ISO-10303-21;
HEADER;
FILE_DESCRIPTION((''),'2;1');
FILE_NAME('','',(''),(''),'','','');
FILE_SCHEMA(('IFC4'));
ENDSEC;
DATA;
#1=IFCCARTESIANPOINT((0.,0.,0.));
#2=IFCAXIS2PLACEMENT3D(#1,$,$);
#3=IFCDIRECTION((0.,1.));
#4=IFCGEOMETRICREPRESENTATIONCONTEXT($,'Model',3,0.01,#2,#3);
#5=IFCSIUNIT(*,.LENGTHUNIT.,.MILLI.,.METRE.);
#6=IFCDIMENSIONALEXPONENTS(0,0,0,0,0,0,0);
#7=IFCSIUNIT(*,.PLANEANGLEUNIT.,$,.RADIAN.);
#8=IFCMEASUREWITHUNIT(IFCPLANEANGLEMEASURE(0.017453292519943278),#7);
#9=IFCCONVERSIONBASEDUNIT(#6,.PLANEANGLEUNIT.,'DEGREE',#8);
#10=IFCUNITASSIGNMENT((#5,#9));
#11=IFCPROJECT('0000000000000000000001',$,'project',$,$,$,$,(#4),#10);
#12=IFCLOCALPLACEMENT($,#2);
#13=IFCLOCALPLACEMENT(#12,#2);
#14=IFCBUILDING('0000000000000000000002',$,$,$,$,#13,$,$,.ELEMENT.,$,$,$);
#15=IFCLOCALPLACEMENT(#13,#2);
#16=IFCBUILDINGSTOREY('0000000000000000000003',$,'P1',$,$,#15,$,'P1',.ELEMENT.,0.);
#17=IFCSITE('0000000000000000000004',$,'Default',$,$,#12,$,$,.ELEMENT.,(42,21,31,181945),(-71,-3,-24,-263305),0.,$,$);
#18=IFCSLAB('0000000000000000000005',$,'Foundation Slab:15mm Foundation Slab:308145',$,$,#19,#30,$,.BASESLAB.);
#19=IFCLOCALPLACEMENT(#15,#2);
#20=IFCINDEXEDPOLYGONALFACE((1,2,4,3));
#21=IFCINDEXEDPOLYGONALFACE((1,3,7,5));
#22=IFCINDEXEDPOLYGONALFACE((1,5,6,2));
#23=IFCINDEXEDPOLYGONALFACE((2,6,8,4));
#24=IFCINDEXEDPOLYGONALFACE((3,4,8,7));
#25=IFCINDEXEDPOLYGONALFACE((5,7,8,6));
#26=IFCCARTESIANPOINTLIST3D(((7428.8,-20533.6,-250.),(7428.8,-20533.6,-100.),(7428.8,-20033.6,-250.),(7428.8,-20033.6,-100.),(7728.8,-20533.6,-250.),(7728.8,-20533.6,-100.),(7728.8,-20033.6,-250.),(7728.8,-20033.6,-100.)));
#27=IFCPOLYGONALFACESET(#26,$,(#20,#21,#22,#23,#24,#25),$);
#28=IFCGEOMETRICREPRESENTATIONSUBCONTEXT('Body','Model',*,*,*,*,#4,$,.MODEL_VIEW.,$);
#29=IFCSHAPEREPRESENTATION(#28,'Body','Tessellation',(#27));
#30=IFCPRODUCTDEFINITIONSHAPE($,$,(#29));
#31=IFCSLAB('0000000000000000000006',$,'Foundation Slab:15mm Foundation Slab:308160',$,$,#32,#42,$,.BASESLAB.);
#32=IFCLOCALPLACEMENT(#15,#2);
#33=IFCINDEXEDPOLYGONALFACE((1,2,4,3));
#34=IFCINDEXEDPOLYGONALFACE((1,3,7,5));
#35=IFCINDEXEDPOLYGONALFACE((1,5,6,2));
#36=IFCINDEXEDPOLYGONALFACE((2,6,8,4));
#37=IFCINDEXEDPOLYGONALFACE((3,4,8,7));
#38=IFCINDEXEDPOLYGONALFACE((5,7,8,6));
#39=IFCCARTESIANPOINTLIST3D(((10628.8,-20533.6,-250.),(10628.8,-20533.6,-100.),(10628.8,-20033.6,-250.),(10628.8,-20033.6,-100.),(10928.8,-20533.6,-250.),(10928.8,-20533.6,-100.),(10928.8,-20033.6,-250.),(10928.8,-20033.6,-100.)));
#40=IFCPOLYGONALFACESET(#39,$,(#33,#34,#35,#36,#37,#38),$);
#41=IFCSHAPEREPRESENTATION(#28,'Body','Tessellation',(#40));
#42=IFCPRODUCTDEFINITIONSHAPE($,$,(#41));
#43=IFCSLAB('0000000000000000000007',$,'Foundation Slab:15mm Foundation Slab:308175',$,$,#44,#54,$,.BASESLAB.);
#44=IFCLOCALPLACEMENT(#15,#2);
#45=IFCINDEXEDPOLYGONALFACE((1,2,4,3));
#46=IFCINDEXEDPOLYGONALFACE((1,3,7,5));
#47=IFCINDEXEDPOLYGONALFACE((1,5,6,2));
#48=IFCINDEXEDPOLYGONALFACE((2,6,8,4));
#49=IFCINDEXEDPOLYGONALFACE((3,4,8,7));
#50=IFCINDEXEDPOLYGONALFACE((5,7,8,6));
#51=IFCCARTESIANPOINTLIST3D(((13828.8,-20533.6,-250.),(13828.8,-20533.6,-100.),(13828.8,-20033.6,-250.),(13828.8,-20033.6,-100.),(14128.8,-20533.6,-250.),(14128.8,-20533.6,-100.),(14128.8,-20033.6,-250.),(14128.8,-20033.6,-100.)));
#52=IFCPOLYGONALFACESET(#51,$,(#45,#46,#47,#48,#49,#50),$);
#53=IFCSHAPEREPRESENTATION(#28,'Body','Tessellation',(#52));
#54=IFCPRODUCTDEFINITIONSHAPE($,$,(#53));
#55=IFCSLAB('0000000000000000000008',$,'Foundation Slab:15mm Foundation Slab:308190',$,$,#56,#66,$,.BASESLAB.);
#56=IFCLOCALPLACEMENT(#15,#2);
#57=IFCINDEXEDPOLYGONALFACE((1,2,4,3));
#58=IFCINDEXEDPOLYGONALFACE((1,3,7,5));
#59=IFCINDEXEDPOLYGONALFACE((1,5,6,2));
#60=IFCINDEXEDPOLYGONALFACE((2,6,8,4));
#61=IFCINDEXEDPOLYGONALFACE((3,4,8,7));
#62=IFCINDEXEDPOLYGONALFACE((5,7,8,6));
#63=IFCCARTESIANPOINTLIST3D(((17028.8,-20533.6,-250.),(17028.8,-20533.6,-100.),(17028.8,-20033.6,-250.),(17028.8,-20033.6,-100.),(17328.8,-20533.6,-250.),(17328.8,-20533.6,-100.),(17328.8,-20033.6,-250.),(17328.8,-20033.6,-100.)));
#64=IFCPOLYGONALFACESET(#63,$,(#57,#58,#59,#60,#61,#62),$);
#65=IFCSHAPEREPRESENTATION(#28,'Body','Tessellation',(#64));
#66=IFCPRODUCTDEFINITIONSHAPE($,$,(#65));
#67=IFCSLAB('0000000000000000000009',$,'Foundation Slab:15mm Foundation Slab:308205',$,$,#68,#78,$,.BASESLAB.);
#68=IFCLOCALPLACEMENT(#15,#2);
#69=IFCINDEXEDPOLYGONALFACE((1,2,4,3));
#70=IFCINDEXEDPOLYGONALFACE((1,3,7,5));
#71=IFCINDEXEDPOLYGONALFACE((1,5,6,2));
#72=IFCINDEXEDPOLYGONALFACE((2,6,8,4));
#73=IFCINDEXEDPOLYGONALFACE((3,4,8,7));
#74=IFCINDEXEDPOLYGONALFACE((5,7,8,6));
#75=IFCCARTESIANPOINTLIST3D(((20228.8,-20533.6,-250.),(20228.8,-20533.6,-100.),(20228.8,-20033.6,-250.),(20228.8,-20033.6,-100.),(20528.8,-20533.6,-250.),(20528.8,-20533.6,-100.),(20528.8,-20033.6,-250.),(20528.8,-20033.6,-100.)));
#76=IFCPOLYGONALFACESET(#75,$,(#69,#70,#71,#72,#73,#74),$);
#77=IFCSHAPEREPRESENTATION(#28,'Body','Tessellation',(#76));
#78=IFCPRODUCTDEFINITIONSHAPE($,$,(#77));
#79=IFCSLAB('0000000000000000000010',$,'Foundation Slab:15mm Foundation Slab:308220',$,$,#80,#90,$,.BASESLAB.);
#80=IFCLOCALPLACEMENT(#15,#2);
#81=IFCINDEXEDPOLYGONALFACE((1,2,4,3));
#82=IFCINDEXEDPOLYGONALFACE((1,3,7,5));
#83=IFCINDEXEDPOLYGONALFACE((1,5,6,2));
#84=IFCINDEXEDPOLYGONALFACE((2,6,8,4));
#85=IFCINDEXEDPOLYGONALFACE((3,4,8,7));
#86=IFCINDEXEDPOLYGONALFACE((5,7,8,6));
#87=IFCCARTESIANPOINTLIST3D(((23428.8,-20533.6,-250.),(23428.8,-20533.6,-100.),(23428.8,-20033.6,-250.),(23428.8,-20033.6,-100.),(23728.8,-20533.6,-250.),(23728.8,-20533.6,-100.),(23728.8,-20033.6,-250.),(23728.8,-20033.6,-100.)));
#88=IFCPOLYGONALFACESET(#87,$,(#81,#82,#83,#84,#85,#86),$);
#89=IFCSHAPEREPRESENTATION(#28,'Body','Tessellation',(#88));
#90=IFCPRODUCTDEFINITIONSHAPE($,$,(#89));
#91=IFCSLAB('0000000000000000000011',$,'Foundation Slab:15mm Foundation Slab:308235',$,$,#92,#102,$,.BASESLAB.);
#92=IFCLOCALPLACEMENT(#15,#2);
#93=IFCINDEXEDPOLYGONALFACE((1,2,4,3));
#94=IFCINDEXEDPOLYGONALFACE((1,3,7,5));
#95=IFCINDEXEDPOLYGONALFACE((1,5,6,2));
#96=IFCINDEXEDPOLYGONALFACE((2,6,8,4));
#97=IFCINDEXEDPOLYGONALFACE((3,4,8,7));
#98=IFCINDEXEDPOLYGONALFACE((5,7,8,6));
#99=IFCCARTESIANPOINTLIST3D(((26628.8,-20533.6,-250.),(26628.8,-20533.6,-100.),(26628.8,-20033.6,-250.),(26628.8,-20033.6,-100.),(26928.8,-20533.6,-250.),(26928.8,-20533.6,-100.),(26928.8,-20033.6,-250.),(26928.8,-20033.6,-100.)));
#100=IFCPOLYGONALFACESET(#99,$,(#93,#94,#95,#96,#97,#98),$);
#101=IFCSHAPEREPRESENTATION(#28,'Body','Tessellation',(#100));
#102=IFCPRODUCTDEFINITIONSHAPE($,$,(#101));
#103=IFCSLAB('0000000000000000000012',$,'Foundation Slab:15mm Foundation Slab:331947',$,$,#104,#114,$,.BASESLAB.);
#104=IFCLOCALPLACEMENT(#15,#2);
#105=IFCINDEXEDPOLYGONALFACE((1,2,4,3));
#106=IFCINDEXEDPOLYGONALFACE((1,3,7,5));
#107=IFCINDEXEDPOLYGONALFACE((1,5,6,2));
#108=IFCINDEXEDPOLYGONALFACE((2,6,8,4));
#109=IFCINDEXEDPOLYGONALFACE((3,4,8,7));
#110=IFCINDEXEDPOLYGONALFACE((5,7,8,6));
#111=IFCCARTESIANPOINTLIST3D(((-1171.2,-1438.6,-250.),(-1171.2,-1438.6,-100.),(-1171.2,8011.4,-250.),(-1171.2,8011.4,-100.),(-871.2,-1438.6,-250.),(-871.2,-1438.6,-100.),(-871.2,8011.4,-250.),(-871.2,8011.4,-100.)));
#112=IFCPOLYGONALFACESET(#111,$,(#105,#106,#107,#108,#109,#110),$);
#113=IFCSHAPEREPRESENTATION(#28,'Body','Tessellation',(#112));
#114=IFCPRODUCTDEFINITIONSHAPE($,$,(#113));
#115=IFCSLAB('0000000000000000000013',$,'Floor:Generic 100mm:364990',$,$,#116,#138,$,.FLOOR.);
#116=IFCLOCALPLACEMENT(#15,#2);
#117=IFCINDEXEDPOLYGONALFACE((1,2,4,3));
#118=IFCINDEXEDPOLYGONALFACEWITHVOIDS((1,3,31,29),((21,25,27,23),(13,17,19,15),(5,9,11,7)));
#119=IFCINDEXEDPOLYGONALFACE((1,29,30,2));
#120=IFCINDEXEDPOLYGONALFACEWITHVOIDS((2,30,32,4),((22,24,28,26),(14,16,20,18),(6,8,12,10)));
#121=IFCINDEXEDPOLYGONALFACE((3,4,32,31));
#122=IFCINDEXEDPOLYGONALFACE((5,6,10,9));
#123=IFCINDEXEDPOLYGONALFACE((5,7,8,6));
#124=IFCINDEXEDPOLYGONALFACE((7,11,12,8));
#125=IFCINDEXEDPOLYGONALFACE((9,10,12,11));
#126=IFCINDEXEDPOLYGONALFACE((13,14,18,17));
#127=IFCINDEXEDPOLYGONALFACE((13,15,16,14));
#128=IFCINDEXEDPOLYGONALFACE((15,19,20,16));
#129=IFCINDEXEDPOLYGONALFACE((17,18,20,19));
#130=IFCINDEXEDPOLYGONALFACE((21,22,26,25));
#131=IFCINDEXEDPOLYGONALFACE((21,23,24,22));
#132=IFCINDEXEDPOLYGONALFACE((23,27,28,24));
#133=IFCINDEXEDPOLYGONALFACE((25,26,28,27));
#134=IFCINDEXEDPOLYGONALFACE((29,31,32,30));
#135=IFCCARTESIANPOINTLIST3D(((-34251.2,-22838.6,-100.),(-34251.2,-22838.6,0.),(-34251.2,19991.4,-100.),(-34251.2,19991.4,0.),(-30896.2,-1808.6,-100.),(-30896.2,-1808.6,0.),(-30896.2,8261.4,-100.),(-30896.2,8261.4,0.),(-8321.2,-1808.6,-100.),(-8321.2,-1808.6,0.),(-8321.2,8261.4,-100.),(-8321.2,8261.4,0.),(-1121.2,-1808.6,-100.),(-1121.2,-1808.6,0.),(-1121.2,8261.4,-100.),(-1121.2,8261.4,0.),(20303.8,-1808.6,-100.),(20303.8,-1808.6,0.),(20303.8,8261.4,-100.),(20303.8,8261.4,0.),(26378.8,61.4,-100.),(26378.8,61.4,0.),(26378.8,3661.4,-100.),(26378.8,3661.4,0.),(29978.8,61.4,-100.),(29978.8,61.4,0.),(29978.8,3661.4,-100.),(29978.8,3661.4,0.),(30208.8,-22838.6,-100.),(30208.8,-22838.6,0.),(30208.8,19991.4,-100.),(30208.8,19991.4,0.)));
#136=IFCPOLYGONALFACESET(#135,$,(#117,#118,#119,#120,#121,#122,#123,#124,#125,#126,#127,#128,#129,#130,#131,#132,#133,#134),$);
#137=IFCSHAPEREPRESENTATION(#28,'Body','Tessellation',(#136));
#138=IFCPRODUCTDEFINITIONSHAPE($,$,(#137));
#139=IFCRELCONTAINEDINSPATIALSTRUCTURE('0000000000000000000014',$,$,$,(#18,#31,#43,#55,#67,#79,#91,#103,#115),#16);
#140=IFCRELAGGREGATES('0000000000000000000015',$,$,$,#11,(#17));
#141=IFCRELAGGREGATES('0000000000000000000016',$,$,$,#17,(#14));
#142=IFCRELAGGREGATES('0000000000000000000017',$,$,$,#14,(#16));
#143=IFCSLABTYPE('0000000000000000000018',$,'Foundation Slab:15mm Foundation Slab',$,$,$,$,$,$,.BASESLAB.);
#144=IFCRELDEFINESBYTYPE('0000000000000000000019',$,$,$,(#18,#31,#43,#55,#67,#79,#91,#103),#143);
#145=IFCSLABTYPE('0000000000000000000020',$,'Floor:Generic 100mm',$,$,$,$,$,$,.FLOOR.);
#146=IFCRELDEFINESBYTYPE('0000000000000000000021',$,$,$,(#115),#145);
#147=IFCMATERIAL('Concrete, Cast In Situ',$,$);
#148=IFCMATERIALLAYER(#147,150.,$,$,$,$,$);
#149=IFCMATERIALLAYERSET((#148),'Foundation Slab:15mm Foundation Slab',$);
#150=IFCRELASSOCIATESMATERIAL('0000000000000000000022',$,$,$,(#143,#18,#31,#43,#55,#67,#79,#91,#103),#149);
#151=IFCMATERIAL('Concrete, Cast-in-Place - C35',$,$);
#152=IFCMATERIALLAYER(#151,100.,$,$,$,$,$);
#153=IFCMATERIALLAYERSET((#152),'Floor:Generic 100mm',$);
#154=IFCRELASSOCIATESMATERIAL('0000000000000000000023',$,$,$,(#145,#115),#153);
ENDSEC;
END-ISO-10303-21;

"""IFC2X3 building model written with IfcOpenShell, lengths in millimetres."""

from ifc_helpers import new_model, entity, si_unit, converted_unit, direction, frame, frame_2d, origin, origin_2d_with_axis, place, context, subcontext, project, spatial, rectangle, extrude, boolean, material, layer, layer_set, layer_usage, type_object, element, save


model = new_model("IFC2X3")

# Units and contexts
model_context = context("Model", 3, precision=0.01, world=origin(), true_north=direction((0.0, 1.0)))
body_context = subcontext(model_context, "Body", "Model", "MODEL_VIEW")
ifc_project = project(units=[si_unit("LENGTHUNIT", "METRE", prefix="MILLI"), converted_unit("PLANEANGLEUNIT", "DEGREE", entity("IfcPlaneAngleMeasure", 0.017453292519943278), si_unit("PLANEANGLEUNIT", "RADIAN"), dimensions=[0, 0, 0, 0, 0, 0, 0])], contexts=[model_context])

# Site, building, storey
site_placement = place(None, origin())
site = spatial("IfcSite", under=ifc_project, at=site_placement, Name="Default", CompositionType="ELEMENT", RefLatitude=(42, 21, 31, 181945), RefLongitude=(-71, -3, -24, -263305), RefElevation=0.0)
building_placement = place(site_placement, origin())
building = spatial("IfcBuilding", under=site, at=building_placement, CompositionType="ELEMENT")
storey_placement = place(building_placement, origin())
storey = spatial("IfcBuildingStorey", under=building, at=storey_placement, Name="P1", LongName="P1", CompositionType="ELEMENT", Elevation=0.0)

# Shared definitions
ifc_material_1 = material(Name="Concrete, Cast-in-Place - C35")

# Slabs
ifc_material_2 = material(Name="Concrete, Cast In Situ")
ifc_layer_1 = layer(ifc_material_2, 150.0)
ifc_layer_set_1 = layer_set([ifc_layer_1], Name="Foundation Slab:15mm Foundation Slab")
slab_type_1 = type_object("IfcSlabType", Name="Foundation Slab:15mm Foundation Slab", PredefinedType="BASESLAB", material=ifc_layer_set_1)
ifc_layer_usage_1 = layer_usage(ifc_layer_set_1, "AXIS3", "POSITIVE", 0.0)
slab_1_placement = place(storey_placement, origin())
element("IfcSlab", 1, at=slab_1_placement, inside=storey, type_object=slab_type_1, material=ifc_layer_usage_1, Name="Foundation Slab:15mm Foundation Slab:308145", PredefinedType="BASESLAB", context=body_context, shape_type="SweptSolid", body=[
    extrude(rectangle(XDim=500.0, YDim=300.0, at=origin_2d_with_axis()), frame((7578.8, -20283.6, -100.0), z_axis=(0.0, 0.0, -1.0), x_axis=(0.0, 1.0, 0.0)), (0.0, 0.0, 1.0), 150.0),
])
ifc_layer_usage_2 = layer_usage(ifc_layer_set_1, "AXIS3", "POSITIVE", 0.0)
slab_2_placement = place(storey_placement, origin())
element("IfcSlab", 2, at=slab_2_placement, inside=storey, type_object=slab_type_1, material=ifc_layer_usage_2, Name="Foundation Slab:15mm Foundation Slab:308160", PredefinedType="BASESLAB", context=body_context, shape_type="SweptSolid", body=[
    extrude(rectangle(XDim=500.0, YDim=300.0, at=origin_2d_with_axis()), frame((10778.8, -20283.6, -100.0), z_axis=(0.0, 0.0, -1.0), x_axis=(0.0, 1.0, 0.0)), (0.0, 0.0, 1.0), 150.0),
])
ifc_layer_usage_3 = layer_usage(ifc_layer_set_1, "AXIS3", "POSITIVE", 0.0)
slab_3_placement = place(storey_placement, origin())
element("IfcSlab", 3, at=slab_3_placement, inside=storey, type_object=slab_type_1, material=ifc_layer_usage_3, Name="Foundation Slab:15mm Foundation Slab:308175", PredefinedType="BASESLAB", context=body_context, shape_type="SweptSolid", body=[
    extrude(rectangle(XDim=500.0, YDim=300.0, at=origin_2d_with_axis()), frame((13978.8, -20283.6, -100.0), z_axis=(0.0, 0.0, -1.0), x_axis=(0.0, 1.0, 0.0)), (0.0, 0.0, 1.0), 150.0),
])
ifc_layer_usage_4 = layer_usage(ifc_layer_set_1, "AXIS3", "POSITIVE", 0.0)
slab_4_placement = place(storey_placement, origin())
element("IfcSlab", 4, at=slab_4_placement, inside=storey, type_object=slab_type_1, material=ifc_layer_usage_4, Name="Foundation Slab:15mm Foundation Slab:308190", PredefinedType="BASESLAB", context=body_context, shape_type="SweptSolid", body=[
    extrude(rectangle(XDim=500.0, YDim=300.0, at=origin_2d_with_axis()), frame((17178.8, -20283.6, -100.0), z_axis=(0.0, 0.0, -1.0), x_axis=(0.0, 1.0, 0.0)), (0.0, 0.0, 1.0), 150.0),
])
ifc_layer_usage_5 = layer_usage(ifc_layer_set_1, "AXIS3", "POSITIVE", 0.0)
slab_5_placement = place(storey_placement, origin())
element("IfcSlab", 5, at=slab_5_placement, inside=storey, type_object=slab_type_1, material=ifc_layer_usage_5, Name="Foundation Slab:15mm Foundation Slab:308205", PredefinedType="BASESLAB", context=body_context, shape_type="SweptSolid", body=[
    extrude(rectangle(XDim=500.0, YDim=300.0, at=origin_2d_with_axis()), frame((20378.8, -20283.6, -100.0), z_axis=(0.0, 0.0, -1.0), x_axis=(0.0, 1.0, 0.0)), (0.0, 0.0, 1.0), 150.0),
])
ifc_layer_usage_6 = layer_usage(ifc_layer_set_1, "AXIS3", "POSITIVE", 0.0)
slab_6_placement = place(storey_placement, origin())
element("IfcSlab", 6, at=slab_6_placement, inside=storey, type_object=slab_type_1, material=ifc_layer_usage_6, Name="Foundation Slab:15mm Foundation Slab:308220", PredefinedType="BASESLAB", context=body_context, shape_type="SweptSolid", body=[
    extrude(rectangle(XDim=500.0, YDim=300.0, at=origin_2d_with_axis()), frame((23578.8, -20283.6, -100.0), z_axis=(0.0, 0.0, -1.0), x_axis=(0.0, 1.0, 0.0)), (0.0, 0.0, 1.0), 150.0),
])
ifc_layer_usage_7 = layer_usage(ifc_layer_set_1, "AXIS3", "POSITIVE", 0.0)
slab_7_placement = place(storey_placement, origin())
element("IfcSlab", 7, at=slab_7_placement, inside=storey, type_object=slab_type_1, material=ifc_layer_usage_7, Name="Foundation Slab:15mm Foundation Slab:308235", PredefinedType="BASESLAB", context=body_context, shape_type="SweptSolid", body=[
    extrude(rectangle(XDim=500.0, YDim=300.0, at=origin_2d_with_axis()), frame((26778.8, -20283.6, -100.0), z_axis=(0.0, 0.0, -1.0), x_axis=(0.0, 1.0, 0.0)), (0.0, 0.0, 1.0), 150.0),
])
ifc_layer_usage_8 = layer_usage(ifc_layer_set_1, "AXIS3", "POSITIVE", 0.0)
slab_8_placement = place(storey_placement, origin())
element("IfcSlab", 8, at=slab_8_placement, inside=storey, type_object=slab_type_1, material=ifc_layer_usage_8, Name="Foundation Slab:15mm Foundation Slab:331947", PredefinedType="BASESLAB", context=body_context, shape_type="SweptSolid", body=[
    extrude(rectangle(XDim=9450.0, YDim=300.0, at=frame_2d((0.0, 0.0), x_axis=(1.0, 0.0))), frame((-1021.2, 3286.4, -100.0), z_axis=(0.0, 0.0, -1.0), x_axis=(0.0, 1.0, 0.0)), (0.0, 0.0, 1.0), 150.0),
])

# Slab, openings
ifc_layer_2 = layer(ifc_material_1, 100.0)
ifc_layer_set_2 = layer_set([ifc_layer_2], Name="Floor:Generic 100mm")
ifc_layer_usage_9 = layer_usage(ifc_layer_set_2, "AXIS3", "POSITIVE", 0.0)
slab_type_2 = type_object("IfcSlabType", Name="Floor:Generic 100mm", PredefinedType="FLOOR", material=ifc_layer_set_2)
slab_9_placement = place(storey_placement, origin())
slab_9 = element("IfcSlab", 9, at=slab_9_placement, inside=storey, type_object=slab_type_2, material=ifc_layer_usage_9, Name="Floor:Generic 100mm:364990", PredefinedType="FLOOR", context=body_context, shape_type="CSG", body=[
    boolean("DIFFERENCE", boolean("DIFFERENCE", boolean("DIFFERENCE", extrude(rectangle(XDim=42830.0, YDim=64460.0, at=origin_2d_with_axis()), frame((-2021.2, -1423.6, 0.0), z_axis=(0.0, 0.0, -1.0), x_axis=(0.0, 1.0, 0.0)), (0.0, 0.0, 1.0), 100.0), extrude(rectangle(XDim=10070.0, YDim=22575.0, at=origin_2d_with_axis()), frame((-19608.7, 3226.4, -100.0), z_axis=(0.0, 0.0, 1.0), x_axis=(0.0, 1.0, 0.0)), (0.0, 0.0, 1.0), 100.0)), extrude(rectangle(XDim=10070.0, YDim=21425.0, at=frame_2d((0.0, 0.0), x_axis=(1.0, 0.0))), frame((9591.3, 3226.4, -100.0), z_axis=(0.0, 0.0, 1.0), x_axis=(0.0, 1.0, 0.0)), (0.0, 0.0, 1.0), 100.0)), extrude(rectangle(XDim=3600.0, YDim=3600.0, at=frame_2d((0.0, 0.0), x_axis=(1.0, 0.0))), frame((28178.8, 1861.4, -100.0), z_axis=(0.0, 0.0, 1.0), x_axis=(0.0, 1.0, 0.0)), (0.0, 0.0, 1.0), 100.0)),
])
opening_1_placement = place(slab_9_placement, origin())
element("IfcOpeningElement", 10, at=opening_1_placement, cuts=slab_9, ObjectType="Opening", context=body_context, shape_type="SweptSolid", body=[
    extrude(rectangle(XDim=3600.0, YDim=3600.0, at=frame_2d((28178.8, 1861.4), x_axis=(0.0, -1.0))), origin(), (0.0, 0.0, -1.0), 100.0),
])
opening_2_placement = place(slab_9_placement, origin())
element("IfcOpeningElement", 11, at=opening_2_placement, cuts=slab_9, ObjectType="Opening", context=body_context, shape_type="SweptSolid", body=[
    extrude(rectangle(XDim=10070.0, YDim=22575.0, at=frame_2d((-19608.7, 3226.4), x_axis=(0.0, -1.0))), origin(), (0.0, 0.0, -1.0), 100.0),
])
opening_3_placement = place(slab_9_placement, origin())
element("IfcOpeningElement", 12, at=opening_3_placement, cuts=slab_9, ObjectType="Opening", context=body_context, shape_type="SweptSolid", body=[
    extrude(rectangle(XDim=10070.0, YDim=21425.0, at=frame_2d((9591.3, 3226.4), x_axis=(0.0, -1.0))), origin(), (0.0, 0.0, -1.0), 100.0),
])

save(model, "model.ifc")
